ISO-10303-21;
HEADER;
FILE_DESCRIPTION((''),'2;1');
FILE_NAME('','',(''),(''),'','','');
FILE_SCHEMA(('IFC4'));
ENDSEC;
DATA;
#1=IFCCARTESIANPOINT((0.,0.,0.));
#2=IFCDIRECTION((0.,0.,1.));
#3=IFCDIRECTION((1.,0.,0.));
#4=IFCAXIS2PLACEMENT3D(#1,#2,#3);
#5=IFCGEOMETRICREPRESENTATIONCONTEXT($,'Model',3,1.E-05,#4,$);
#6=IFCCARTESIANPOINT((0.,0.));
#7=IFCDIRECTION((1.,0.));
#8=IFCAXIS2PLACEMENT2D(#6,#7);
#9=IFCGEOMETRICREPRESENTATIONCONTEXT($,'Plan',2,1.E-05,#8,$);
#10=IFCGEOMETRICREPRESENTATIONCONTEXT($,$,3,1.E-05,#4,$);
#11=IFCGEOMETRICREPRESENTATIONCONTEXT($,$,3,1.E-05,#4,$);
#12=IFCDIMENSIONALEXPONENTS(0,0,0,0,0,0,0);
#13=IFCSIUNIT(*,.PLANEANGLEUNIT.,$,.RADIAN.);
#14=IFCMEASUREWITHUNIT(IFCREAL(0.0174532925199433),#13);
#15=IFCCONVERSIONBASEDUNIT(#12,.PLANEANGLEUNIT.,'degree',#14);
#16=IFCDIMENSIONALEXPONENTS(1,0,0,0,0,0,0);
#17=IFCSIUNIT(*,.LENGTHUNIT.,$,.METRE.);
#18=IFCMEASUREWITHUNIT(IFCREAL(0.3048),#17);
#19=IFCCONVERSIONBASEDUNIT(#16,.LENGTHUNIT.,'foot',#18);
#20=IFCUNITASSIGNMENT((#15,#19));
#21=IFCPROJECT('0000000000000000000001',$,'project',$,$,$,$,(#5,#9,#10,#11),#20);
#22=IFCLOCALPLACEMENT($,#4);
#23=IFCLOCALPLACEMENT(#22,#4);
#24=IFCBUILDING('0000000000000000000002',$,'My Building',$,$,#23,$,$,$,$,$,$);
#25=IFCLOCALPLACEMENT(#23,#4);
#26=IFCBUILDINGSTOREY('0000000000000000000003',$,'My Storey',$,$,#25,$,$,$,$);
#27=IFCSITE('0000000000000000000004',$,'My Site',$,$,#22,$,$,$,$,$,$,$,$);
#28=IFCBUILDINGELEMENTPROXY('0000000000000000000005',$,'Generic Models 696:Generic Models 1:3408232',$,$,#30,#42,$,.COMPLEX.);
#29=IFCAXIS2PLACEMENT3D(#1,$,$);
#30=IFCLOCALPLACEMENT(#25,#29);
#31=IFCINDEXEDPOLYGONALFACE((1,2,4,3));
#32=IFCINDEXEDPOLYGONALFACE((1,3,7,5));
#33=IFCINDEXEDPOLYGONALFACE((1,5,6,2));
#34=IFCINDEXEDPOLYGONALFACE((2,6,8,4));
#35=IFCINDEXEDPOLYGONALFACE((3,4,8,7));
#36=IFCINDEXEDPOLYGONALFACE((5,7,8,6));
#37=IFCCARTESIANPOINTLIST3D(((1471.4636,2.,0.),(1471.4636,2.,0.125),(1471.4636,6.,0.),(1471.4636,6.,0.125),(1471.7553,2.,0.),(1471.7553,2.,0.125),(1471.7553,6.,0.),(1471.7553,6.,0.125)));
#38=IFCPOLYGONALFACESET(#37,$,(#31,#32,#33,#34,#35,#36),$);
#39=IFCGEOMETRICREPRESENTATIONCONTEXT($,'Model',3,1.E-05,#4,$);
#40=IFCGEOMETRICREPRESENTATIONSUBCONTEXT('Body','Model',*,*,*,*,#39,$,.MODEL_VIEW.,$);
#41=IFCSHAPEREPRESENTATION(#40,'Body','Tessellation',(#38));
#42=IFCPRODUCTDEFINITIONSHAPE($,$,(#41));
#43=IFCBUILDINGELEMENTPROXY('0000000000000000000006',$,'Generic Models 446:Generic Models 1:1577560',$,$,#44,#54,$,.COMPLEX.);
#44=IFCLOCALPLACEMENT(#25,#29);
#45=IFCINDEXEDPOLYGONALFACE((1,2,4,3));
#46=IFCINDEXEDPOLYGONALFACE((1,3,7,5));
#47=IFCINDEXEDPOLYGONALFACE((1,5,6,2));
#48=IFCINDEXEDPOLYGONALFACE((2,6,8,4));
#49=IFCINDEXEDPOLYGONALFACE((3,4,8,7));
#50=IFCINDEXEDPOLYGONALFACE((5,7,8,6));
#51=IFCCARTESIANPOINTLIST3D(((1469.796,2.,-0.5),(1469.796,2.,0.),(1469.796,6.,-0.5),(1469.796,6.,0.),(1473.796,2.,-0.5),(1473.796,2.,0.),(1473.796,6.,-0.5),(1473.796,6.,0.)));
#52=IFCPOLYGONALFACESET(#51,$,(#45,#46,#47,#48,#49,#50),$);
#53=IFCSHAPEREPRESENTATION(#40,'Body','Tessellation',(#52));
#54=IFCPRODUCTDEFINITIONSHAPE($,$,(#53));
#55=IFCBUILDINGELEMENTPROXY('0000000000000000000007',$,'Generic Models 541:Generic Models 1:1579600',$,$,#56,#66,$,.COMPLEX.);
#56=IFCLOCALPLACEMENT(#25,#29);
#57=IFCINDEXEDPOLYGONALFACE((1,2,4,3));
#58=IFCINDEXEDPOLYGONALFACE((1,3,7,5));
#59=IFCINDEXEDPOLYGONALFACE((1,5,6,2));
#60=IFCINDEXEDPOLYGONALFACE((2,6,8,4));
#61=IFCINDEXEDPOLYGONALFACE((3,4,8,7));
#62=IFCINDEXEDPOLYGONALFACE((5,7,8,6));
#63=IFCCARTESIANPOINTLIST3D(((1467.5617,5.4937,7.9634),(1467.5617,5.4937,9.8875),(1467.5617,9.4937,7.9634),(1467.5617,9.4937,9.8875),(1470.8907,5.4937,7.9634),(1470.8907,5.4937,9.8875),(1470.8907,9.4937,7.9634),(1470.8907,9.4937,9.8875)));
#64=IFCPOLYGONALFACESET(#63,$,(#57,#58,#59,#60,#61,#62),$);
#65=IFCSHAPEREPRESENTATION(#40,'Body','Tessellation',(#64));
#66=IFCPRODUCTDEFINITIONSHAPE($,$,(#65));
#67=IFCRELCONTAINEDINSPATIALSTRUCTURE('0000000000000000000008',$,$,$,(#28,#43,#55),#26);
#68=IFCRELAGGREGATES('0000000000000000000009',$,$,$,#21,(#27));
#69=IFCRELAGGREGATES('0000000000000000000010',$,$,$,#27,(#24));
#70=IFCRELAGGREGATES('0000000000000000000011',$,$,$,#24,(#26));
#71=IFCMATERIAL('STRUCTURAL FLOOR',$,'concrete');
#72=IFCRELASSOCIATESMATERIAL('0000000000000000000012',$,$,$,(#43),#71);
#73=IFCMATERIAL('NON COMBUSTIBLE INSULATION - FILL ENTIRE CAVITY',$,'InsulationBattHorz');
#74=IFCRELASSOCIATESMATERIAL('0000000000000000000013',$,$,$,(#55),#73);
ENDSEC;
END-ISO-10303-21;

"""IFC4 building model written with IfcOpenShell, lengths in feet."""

from ifc_helpers import new_model, entity, si_unit, converted_unit, frame, origin_with_axes, origin_2d_with_axis, place, context, subcontext, project, spatial, polyline, outline, extrude, material, element, save


model = new_model("IFC4")

# Units and contexts
model_context_1 = context("Model", 3, precision=1e-05, world=origin_with_axes())
plan_context = context("Plan", 2, precision=1e-05, world=origin_2d_with_axis())
model_context_2 = context("Model", 3, precision=1e-05, world=origin_with_axes())
context_of_model_1 = context(None, 3, precision=1e-05, world=origin_with_axes())
context_of_model_2 = context(None, 3, precision=1e-05, world=origin_with_axes())
body_context = subcontext(model_context_2, "Body", "Model", "MODEL_VIEW")
ifc_project = project(units=[converted_unit("PLANEANGLEUNIT", "degree", entity("IfcReal", 0.0174532925199433), si_unit("PLANEANGLEUNIT", "RADIAN"), dimensions=[0, 0, 0, 0, 0, 0, 0]), converted_unit("LENGTHUNIT", "foot", entity("IfcReal", 0.3048), si_unit("LENGTHUNIT", "METRE"), dimensions=[1, 0, 0, 0, 0, 0, 0])], contexts=[model_context_1, plan_context, context_of_model_1, context_of_model_2])

# Site, building, storey
site_placement = place(None, origin_with_axes())
site = spatial("IfcSite", under=ifc_project, at=site_placement, Name="My Site")
building_placement = place(site_placement, origin_with_axes())
building = spatial("IfcBuilding", under=site, at=building_placement, Name="My Building")
storey_placement = place(building_placement, origin_with_axes())
storey = spatial("IfcBuildingStorey", under=building, at=storey_placement, Name="My Storey")

# Building element proxies
ifc_material_1 = material(Name="STRUCTURAL FLOOR", Category="concrete")
proxy_1_placement = place(storey_placement, frame((1471.4636, 6.0, 0.0), z_axis=(0.0, -1.0, 0.0), x_axis=(0.0, 0.0, 1.0)))
element("IfcBuildingElementProxy", 1, at=proxy_1_placement, inside=storey, Name="Generic Models 696:Generic Models 1:3408232", PredefinedType="COMPLEX", context=body_context, shape_type="SweptSolid", body=[
    extrude(outline(polyline([(-0.0625, -0.1458), (0.0625, -0.1458), (0.0625, 0.1458), (-0.0625, 0.1458), (-0.0625, -0.1458)])), frame((0.0625, -0.1458, 0.0), z_axis=(0.0, 0.0, -1.0), x_axis=(1.0, 0.0, 0.0)), (0.0, 0.0, -1.0), 4.0),
])
proxy_2_placement = place(storey_placement, frame((1469.796, 6.0, -0.5), z_axis=(0.0, -1.0, 0.0), x_axis=(0.0, 0.0, 1.0)))
element("IfcBuildingElementProxy", 2, at=proxy_2_placement, inside=storey, material=ifc_material_1, Name="Generic Models 446:Generic Models 1:1577560", PredefinedType="COMPLEX", context=body_context, shape_type="SweptSolid", body=[
    extrude(outline(polyline([(-2.0, -0.25), (2.0, -0.25), (2.0, 0.25), (-2.0, 0.25), (-2.0, -0.25)])), frame((0.25, -2.0, 0.0), z_axis=(0.0, 0.0, -1.0), x_axis=(0.0, 1.0, 0.0)), (0.0, 0.0, -1.0), 4.0),
])
ifc_material_2 = material(Name="NON COMBUSTIBLE INSULATION - FILL ENTIRE CAVITY", Category="InsulationBattHorz")
proxy_3_placement = place(storey_placement, frame((1470.2593, 9.4937, -0.055), z_axis=(0.0, -1.0, 0.0), x_axis=(0.0, 0.0, 1.0)))
element("IfcBuildingElementProxy", 3, at=proxy_3_placement, inside=storey, material=ifc_material_2, Name="Generic Models 541:Generic Models 1:1579600", PredefinedType="COMPLEX", context=body_context, shape_type="SweptSolid", body=[
    extrude(outline(polyline([(-0.9621, -1.6645), (0.9621, -1.6645), (0.9621, 1.6645), (-0.9621, 1.6645), (-0.9621, -1.6645)])), frame((8.9804, 1.0331, 0.0), z_axis=(0.0, 0.0, -1.0), x_axis=(-1.0, -0.000001, 0.0)), (0.0, 0.0, -1.0), 4.0),
])

save(model, "model.ifc")
